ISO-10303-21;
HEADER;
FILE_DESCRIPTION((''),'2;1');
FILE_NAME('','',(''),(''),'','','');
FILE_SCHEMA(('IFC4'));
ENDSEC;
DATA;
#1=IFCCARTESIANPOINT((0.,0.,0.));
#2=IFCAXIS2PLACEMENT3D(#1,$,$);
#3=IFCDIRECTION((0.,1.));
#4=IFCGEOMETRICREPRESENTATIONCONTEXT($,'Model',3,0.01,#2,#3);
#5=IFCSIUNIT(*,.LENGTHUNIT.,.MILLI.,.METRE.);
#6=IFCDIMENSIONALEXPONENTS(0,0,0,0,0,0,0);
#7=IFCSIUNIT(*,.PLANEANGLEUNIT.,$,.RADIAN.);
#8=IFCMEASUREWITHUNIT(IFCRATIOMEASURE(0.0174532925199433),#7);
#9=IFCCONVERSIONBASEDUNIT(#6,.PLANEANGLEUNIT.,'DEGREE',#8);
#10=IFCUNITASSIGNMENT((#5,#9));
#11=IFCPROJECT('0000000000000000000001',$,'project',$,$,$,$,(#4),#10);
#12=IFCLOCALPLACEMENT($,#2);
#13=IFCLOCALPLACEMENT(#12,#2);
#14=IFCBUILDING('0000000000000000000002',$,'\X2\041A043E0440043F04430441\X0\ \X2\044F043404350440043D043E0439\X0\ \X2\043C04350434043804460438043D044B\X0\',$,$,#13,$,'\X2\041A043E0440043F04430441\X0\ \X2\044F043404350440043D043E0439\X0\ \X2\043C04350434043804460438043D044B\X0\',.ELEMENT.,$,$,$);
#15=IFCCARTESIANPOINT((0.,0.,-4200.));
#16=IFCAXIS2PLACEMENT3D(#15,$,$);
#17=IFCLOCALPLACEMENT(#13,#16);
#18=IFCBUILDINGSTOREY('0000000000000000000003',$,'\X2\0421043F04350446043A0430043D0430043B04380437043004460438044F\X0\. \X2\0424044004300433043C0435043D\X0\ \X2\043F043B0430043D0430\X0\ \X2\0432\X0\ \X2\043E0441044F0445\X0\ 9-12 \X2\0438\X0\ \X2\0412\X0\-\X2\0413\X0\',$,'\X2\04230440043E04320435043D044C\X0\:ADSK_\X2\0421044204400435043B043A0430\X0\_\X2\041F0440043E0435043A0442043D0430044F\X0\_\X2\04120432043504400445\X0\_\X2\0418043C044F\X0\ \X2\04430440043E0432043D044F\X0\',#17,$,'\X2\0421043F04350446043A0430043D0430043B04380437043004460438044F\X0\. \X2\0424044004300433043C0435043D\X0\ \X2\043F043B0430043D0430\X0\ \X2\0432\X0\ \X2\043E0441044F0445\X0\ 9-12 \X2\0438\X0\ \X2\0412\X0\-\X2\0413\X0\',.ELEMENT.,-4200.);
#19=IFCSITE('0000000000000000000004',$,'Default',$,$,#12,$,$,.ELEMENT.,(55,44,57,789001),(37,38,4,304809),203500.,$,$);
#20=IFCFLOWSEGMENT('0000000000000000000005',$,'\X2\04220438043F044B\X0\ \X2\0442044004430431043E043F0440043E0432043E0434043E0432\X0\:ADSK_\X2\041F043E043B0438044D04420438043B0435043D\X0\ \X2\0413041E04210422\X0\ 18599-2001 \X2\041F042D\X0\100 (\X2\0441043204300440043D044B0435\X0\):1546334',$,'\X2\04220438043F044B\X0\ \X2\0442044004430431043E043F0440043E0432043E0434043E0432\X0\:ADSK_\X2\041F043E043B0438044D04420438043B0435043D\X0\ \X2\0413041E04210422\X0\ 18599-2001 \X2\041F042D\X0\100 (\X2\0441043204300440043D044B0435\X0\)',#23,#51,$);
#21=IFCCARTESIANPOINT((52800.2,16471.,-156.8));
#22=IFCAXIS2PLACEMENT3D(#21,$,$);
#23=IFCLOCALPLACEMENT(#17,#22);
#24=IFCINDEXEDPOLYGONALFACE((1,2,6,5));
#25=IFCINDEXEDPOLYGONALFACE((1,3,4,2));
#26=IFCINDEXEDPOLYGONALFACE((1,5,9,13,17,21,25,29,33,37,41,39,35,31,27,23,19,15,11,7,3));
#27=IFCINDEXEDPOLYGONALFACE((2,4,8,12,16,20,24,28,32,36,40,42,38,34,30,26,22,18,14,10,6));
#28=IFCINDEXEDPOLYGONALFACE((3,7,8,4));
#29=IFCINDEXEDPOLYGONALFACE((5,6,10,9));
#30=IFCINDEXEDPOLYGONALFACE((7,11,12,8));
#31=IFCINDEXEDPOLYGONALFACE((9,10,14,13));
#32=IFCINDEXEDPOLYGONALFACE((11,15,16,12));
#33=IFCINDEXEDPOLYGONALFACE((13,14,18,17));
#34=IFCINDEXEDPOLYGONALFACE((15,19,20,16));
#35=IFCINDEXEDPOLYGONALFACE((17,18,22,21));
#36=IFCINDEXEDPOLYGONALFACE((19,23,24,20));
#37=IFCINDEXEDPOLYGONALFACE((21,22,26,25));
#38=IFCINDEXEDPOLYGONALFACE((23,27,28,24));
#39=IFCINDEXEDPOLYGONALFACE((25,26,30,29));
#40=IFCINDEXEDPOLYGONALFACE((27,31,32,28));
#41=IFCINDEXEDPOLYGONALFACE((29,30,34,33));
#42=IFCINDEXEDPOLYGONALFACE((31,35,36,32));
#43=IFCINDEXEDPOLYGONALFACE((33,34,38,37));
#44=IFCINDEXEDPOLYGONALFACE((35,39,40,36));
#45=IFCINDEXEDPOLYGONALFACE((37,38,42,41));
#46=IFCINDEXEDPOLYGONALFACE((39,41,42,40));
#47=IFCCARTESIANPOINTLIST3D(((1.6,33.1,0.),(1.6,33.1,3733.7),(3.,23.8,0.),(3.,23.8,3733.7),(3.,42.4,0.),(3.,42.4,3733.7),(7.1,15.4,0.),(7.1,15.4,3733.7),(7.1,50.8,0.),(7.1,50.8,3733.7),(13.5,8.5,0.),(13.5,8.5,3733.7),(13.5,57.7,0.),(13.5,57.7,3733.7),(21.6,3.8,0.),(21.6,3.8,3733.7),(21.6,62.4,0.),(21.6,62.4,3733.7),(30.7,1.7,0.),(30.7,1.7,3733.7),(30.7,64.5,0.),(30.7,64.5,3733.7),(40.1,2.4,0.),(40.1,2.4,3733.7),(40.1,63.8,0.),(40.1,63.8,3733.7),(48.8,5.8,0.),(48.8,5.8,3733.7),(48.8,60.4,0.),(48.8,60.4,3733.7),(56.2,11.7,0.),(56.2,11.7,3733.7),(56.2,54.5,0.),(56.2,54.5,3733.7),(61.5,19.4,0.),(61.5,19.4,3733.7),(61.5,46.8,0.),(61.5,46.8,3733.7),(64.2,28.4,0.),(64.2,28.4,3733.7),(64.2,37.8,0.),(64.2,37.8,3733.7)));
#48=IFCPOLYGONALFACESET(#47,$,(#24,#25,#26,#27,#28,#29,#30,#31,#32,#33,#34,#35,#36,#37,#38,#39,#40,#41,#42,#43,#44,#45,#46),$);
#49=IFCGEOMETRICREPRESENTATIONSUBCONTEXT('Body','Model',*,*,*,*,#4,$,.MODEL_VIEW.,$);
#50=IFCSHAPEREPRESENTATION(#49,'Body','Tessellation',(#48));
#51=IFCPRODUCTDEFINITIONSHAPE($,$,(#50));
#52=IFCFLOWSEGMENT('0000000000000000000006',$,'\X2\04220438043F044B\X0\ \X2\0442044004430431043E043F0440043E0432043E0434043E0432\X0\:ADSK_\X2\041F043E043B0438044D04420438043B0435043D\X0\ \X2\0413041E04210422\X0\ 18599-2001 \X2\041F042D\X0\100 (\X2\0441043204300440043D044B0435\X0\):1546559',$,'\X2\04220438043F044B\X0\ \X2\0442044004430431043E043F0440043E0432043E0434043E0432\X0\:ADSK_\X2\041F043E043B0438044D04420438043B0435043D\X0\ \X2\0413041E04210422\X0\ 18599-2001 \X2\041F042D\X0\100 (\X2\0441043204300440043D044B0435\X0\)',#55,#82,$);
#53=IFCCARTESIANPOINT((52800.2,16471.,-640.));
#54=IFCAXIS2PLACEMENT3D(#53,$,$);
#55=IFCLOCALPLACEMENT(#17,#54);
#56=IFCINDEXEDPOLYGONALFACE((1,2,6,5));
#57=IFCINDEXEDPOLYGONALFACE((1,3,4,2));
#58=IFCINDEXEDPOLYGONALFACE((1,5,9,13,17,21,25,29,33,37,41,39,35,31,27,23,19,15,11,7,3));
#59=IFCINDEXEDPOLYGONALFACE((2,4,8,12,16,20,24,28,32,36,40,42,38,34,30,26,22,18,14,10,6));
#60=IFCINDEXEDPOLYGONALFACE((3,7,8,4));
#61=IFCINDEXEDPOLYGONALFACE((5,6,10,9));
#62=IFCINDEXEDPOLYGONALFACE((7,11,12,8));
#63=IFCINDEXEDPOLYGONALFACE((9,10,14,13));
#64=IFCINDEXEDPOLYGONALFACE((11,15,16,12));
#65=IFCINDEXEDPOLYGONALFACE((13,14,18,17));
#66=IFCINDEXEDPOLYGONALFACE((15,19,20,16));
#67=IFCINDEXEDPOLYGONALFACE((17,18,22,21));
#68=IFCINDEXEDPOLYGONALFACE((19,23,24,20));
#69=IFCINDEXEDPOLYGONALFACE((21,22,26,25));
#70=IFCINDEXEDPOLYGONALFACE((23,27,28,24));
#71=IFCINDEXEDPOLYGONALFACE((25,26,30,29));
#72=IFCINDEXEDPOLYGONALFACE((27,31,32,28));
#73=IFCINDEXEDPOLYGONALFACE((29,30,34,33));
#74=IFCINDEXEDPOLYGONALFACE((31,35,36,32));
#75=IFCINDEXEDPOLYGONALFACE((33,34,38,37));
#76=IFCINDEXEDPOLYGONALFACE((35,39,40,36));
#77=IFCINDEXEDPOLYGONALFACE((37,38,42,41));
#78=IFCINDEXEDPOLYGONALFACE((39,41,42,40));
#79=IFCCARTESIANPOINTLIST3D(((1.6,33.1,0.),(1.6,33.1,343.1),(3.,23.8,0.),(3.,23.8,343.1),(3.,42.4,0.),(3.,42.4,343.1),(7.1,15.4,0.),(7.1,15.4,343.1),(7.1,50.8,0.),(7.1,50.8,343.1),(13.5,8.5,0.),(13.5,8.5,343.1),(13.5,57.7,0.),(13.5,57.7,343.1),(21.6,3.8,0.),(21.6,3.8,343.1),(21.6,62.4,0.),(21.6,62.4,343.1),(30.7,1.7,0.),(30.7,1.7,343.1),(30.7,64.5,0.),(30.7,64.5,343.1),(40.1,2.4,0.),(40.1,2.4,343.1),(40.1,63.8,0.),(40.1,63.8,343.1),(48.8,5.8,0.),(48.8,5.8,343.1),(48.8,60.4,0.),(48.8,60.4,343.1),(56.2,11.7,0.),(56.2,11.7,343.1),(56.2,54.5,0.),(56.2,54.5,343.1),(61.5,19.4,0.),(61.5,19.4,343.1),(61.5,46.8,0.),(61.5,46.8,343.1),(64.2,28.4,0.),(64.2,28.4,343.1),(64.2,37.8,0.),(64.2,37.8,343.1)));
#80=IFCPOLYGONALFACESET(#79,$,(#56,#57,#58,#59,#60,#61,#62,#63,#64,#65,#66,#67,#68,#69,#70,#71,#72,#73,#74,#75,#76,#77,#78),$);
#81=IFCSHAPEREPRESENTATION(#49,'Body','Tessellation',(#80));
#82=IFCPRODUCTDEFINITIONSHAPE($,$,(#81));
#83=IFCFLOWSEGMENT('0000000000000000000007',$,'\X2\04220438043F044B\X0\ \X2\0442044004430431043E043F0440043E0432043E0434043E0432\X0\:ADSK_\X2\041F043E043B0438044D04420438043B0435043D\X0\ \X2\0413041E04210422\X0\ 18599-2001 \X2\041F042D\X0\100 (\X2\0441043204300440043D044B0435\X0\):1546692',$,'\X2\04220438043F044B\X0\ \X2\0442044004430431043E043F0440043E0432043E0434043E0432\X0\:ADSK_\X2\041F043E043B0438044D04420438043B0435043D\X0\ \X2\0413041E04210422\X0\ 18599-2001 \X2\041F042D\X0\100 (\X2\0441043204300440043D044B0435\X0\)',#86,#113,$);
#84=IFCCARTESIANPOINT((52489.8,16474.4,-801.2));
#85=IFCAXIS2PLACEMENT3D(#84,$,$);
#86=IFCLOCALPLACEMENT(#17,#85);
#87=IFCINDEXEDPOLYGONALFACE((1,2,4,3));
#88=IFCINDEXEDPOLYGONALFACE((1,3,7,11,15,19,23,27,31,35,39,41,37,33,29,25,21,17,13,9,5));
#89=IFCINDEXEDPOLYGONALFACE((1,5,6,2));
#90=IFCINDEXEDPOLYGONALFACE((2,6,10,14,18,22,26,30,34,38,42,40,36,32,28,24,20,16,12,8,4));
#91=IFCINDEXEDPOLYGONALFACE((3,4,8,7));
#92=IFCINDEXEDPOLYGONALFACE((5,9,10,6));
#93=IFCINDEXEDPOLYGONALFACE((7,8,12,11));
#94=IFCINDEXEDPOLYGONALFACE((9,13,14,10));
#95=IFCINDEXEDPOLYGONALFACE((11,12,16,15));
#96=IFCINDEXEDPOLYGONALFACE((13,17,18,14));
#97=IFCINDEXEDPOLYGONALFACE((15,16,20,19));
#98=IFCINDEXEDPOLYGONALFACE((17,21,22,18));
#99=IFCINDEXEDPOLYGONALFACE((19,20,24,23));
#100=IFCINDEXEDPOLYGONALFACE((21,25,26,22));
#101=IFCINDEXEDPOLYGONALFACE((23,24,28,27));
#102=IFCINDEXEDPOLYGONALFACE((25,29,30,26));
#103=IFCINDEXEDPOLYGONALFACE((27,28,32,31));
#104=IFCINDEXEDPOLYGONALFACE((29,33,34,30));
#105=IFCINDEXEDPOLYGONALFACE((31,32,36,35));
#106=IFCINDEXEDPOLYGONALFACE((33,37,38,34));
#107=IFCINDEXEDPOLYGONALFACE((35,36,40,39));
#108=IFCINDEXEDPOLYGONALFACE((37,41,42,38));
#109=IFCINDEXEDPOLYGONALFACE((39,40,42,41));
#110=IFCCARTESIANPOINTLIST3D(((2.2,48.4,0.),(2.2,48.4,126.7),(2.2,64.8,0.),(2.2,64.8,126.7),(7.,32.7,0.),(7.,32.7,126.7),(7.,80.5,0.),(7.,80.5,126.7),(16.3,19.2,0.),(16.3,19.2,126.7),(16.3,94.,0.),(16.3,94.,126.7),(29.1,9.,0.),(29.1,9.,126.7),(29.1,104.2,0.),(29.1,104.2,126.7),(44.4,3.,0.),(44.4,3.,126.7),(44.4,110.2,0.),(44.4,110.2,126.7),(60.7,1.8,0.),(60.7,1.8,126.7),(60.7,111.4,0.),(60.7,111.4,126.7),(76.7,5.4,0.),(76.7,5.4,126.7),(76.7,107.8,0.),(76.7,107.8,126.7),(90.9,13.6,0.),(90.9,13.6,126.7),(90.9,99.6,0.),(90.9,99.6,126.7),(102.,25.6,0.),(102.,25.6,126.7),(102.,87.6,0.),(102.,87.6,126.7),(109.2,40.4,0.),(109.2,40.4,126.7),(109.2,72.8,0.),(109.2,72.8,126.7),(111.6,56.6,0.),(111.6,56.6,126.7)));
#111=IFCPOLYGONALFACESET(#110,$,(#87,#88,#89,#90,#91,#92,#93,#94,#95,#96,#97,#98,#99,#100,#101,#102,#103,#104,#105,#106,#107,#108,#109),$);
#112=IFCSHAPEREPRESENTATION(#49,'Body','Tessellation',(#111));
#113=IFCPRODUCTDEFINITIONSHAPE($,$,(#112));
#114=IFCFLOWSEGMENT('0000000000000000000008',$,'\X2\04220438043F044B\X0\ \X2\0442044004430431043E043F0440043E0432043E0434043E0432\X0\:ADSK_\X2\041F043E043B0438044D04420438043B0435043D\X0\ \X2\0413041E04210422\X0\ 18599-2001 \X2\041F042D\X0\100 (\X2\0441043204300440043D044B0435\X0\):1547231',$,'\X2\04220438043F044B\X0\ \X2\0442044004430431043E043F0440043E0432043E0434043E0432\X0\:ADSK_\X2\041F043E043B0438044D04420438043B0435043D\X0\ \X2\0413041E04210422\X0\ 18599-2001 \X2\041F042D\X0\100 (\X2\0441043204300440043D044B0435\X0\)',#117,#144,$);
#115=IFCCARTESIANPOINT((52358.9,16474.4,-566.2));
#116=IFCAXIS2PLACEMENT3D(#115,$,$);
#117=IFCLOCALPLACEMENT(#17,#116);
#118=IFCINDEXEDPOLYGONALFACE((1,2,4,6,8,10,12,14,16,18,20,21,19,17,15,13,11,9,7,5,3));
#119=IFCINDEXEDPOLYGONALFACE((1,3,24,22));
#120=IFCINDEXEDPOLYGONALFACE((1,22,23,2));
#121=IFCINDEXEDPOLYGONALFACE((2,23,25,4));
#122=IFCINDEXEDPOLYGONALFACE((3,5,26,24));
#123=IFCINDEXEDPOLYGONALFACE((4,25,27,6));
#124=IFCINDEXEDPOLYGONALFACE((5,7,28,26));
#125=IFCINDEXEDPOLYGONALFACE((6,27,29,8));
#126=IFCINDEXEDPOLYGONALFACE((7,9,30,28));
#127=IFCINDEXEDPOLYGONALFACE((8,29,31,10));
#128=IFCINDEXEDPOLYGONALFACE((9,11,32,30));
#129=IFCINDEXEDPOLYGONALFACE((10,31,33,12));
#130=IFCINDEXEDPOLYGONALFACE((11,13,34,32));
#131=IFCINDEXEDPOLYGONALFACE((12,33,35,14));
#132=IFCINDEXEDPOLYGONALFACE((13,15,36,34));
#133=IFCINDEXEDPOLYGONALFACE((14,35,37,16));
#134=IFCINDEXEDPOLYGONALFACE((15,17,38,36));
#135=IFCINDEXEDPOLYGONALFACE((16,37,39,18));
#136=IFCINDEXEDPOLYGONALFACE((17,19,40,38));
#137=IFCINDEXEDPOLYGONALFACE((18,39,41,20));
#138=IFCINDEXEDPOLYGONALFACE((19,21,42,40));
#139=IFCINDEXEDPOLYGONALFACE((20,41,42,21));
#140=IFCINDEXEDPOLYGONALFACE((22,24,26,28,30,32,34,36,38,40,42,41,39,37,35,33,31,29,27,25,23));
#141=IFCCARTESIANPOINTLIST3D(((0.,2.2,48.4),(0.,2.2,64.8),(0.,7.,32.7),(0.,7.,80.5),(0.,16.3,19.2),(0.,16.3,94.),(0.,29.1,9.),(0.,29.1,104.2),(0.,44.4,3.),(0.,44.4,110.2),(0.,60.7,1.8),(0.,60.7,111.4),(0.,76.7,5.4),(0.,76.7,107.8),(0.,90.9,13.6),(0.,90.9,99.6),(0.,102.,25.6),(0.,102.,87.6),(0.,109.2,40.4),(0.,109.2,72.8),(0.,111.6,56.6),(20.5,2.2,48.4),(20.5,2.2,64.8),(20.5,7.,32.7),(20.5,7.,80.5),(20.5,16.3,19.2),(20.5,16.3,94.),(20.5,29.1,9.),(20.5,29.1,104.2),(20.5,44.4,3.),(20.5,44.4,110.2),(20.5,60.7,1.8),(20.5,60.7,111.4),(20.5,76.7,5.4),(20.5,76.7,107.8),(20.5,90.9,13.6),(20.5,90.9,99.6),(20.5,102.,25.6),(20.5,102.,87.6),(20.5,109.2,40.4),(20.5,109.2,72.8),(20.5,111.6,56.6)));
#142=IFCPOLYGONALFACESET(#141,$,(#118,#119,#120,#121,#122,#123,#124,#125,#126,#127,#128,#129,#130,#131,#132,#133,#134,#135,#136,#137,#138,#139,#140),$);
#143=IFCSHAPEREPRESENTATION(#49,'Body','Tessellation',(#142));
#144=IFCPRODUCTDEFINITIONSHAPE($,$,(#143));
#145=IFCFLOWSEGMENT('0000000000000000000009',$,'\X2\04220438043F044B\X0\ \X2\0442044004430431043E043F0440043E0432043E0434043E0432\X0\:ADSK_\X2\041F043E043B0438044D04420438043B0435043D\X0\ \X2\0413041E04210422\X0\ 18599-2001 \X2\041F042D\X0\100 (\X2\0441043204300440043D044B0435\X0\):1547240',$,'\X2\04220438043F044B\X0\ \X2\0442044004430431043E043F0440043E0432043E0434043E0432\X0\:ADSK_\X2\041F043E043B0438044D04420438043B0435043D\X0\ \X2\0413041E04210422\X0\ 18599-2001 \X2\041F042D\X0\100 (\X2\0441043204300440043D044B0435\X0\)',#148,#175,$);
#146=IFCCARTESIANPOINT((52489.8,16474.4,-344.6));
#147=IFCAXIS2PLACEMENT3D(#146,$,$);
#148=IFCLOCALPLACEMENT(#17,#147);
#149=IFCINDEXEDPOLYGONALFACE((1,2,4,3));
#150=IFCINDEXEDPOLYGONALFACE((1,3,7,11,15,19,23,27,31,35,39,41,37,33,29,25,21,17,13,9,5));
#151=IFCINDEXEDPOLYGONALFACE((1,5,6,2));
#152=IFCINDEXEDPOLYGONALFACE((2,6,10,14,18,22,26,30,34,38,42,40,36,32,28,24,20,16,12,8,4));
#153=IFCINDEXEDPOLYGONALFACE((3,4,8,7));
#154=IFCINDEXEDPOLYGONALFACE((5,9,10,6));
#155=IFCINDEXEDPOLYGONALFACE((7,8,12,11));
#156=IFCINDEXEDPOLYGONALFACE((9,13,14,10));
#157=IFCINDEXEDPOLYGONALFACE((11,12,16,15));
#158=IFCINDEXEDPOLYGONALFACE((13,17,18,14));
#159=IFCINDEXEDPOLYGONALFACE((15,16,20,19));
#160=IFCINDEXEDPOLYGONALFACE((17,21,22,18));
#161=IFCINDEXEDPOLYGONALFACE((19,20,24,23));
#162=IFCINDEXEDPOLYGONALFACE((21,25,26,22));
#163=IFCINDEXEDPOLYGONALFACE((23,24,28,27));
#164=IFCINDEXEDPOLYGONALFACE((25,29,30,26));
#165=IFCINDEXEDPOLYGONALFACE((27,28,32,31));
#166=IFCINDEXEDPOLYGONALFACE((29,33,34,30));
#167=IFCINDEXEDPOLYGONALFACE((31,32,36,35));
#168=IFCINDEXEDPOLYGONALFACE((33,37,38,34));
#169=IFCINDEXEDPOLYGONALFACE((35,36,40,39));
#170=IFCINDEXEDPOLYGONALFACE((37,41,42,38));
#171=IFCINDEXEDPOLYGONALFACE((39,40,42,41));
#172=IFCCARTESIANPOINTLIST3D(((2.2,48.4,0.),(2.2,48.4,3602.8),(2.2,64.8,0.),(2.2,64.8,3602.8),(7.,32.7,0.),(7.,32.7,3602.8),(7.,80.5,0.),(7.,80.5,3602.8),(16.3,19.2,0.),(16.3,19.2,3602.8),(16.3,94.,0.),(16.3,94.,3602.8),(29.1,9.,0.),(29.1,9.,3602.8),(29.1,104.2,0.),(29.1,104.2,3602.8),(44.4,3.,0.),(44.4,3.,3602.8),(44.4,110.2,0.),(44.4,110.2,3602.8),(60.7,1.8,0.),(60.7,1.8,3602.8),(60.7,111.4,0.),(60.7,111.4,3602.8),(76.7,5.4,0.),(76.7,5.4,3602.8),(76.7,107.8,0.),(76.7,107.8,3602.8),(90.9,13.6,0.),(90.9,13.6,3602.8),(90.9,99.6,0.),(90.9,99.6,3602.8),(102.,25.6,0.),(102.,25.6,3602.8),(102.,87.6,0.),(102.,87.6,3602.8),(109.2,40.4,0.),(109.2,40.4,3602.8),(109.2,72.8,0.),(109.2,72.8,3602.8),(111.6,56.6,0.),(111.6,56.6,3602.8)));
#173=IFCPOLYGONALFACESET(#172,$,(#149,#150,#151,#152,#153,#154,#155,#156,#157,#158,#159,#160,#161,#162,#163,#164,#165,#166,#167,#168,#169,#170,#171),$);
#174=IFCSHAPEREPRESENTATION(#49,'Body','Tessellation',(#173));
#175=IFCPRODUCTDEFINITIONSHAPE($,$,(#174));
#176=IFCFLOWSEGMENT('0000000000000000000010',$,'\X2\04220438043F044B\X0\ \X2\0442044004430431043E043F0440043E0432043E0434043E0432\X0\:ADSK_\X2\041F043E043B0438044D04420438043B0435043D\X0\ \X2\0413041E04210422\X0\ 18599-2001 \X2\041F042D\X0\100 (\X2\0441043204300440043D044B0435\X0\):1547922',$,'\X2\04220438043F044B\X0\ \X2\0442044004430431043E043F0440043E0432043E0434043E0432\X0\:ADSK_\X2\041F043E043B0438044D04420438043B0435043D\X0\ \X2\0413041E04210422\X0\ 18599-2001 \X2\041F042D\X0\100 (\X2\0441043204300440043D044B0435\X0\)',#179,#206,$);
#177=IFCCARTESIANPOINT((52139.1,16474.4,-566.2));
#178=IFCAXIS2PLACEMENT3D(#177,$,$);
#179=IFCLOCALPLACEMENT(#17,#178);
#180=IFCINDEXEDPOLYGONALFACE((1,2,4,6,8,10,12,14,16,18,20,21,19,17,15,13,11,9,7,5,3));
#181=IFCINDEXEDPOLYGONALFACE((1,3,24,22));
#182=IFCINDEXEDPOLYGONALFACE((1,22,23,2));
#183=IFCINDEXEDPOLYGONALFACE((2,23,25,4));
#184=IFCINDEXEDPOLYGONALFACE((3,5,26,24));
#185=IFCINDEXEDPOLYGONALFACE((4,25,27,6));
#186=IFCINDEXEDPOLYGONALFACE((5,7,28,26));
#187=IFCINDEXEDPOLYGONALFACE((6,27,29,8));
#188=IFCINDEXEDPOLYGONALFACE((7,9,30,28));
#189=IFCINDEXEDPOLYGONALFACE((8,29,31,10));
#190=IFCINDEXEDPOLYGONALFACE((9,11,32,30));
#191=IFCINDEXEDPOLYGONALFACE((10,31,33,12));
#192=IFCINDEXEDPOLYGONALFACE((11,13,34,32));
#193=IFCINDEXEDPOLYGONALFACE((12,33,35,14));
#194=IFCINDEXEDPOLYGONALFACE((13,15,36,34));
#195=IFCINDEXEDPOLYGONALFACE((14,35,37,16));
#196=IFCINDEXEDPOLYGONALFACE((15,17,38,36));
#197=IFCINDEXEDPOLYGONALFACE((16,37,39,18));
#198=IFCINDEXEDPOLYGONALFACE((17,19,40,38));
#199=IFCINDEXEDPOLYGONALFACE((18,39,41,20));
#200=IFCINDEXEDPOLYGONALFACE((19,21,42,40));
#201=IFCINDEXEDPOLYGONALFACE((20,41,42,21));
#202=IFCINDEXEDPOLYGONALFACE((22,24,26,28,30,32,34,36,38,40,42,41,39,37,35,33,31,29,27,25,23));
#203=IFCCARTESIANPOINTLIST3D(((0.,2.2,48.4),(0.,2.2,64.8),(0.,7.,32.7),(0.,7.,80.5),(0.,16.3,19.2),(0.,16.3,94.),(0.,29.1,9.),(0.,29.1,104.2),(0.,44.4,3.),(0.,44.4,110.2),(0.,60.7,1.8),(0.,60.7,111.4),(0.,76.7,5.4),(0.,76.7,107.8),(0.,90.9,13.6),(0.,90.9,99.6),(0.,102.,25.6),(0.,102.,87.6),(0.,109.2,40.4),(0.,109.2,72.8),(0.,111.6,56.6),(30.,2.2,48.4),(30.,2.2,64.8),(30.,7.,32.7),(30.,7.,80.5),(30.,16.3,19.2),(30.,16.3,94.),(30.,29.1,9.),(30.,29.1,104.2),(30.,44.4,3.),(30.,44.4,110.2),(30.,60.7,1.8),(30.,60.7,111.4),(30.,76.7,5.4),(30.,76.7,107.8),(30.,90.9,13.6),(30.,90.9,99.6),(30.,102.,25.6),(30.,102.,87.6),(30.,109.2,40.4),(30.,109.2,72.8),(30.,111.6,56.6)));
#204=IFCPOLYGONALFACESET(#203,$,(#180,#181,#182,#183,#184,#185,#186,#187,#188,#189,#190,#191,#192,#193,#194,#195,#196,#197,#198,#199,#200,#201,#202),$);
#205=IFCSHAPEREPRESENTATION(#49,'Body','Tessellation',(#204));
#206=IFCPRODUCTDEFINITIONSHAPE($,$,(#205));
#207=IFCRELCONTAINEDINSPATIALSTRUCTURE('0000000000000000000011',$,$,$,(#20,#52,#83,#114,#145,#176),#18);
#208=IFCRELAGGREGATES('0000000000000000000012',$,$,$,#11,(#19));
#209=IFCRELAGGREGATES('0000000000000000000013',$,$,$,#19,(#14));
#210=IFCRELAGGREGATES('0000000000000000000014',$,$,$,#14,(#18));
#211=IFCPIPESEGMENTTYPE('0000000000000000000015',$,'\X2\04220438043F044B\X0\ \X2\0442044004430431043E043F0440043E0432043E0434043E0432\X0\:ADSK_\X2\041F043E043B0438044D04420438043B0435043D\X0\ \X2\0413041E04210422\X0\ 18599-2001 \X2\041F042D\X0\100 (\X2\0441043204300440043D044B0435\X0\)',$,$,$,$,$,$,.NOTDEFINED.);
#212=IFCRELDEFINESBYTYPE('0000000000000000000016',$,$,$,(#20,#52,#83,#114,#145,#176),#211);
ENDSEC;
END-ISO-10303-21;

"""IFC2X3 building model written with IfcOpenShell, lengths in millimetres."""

from ifc_helpers import new_model, entity, si_unit, converted_unit, direction, frame, origin, origin_2d_with_axis, place, context, subcontext, project, spatial, circle, extrude, type_object, element, save


model = new_model("IFC2X3")

# Units and contexts
model_context = context("Model", 3, precision=0.01, world=origin(), true_north=direction((0.0, 1.0)))
body_context = subcontext(model_context, "Body", "Model", "MODEL_VIEW")
ifc_project = project(units=[si_unit("LENGTHUNIT", "METRE", prefix="MILLI"), converted_unit("PLANEANGLEUNIT", "DEGREE", entity("IfcRatioMeasure", 0.0174532925199433), si_unit("PLANEANGLEUNIT", "RADIAN"), dimensions=[0, 0, 0, 0, 0, 0, 0])], contexts=[model_context])

# Site, building, storey
site_placement = place(None, origin())
site = spatial("IfcSite", under=ifc_project, at=site_placement, Name="Default", CompositionType="ELEMENT", RefLatitude=(55, 44, 57, 789001), RefLongitude=(37, 38, 4, 304809), RefElevation=203500.0)
building_placement = place(site_placement, origin())
building = spatial("IfcBuilding", under=site, at=building_placement, Name="Корпус ядерной медицины", LongName="Корпус ядерной медицины", CompositionType="ELEMENT")
storey_placement = place(building_placement, frame((0.0, 0.0, -4200.0)))
storey = spatial("IfcBuildingStorey", under=building, at=storey_placement, Name="Спецканализация. Фрагмен плана в осях 9-12 и В-Г", ObjectType="Уровень:ADSK_Стрелка_Проектная_Вверх_Имя уровня", LongName="Спецканализация. Фрагмен плана в осях 9-12 и В-Г", CompositionType="ELEMENT", Elevation=-4200.0)

# Flow segments
pipe_segment_type = type_object("IfcPipeSegmentType", Name="Типы трубопроводов:ADSK_Полиэтилен ГОСТ 18599-2001 ПЭ100 (сварные)", PredefinedType="NOTDEFINED")
flow_segment_1_placement = place(storey_placement, frame((52800.2, 16471.0, -156.8)))
element("IfcFlowSegment", 1, at=flow_segment_1_placement, inside=storey, type_object=pipe_segment_type, Name="Типы трубопроводов:ADSK_Полиэтилен ГОСТ 18599-2001 ПЭ100 (сварные):1546334", ObjectType="Типы трубопроводов:ADSK_Полиэтилен ГОСТ 18599-2001 ПЭ100 (сварные)", context=body_context, shape_type="SweptSolid", body=[
    extrude(circle(Radius=31.5, at=origin_2d_with_axis()), frame((33.1, 33.1, 0.0), z_axis=(0.0, 0.0, 1.0), x_axis=(-1.0, 0.0, 0.0)), (0.0, 0.0, 1.0), 3733.7),
])
flow_segment_2_placement = place(storey_placement, frame((52800.2, 16471.0, -640.0)))
element("IfcFlowSegment", 2, at=flow_segment_2_placement, inside=storey, type_object=pipe_segment_type, Name="Типы трубопроводов:ADSK_Полиэтилен ГОСТ 18599-2001 ПЭ100 (сварные):1546559", ObjectType="Типы трубопроводов:ADSK_Полиэтилен ГОСТ 18599-2001 ПЭ100 (сварные)", context=body_context, shape_type="SweptSolid", body=[
    extrude(circle(Radius=31.5, at=origin_2d_with_axis()), frame((33.1, 33.1, 0.0), z_axis=(0.0, 0.0, 1.0), x_axis=(-1.0, 0.0, 0.0)), (0.0, 0.0, 1.0), 343.1),
])
flow_segment_3_placement = place(storey_placement, frame((52489.8, 16474.4, -801.2)))
element("IfcFlowSegment", 3, at=flow_segment_3_placement, inside=storey, type_object=pipe_segment_type, Name="Типы трубопроводов:ADSK_Полиэтилен ГОСТ 18599-2001 ПЭ100 (сварные):1546692", ObjectType="Типы трубопроводов:ADSK_Полиэтилен ГОСТ 18599-2001 ПЭ100 (сварные)", context=body_context, shape_type="SweptSolid", body=[
    extrude(circle(Radius=55.0, at=origin_2d_with_axis()), frame((56.6, 56.6, 0.0)), (0.0, 0.0, 1.0), 126.7),
])
flow_segment_4_placement = place(storey_placement, frame((52358.9, 16474.4, -566.2)))
element("IfcFlowSegment", 4, at=flow_segment_4_placement, inside=storey, type_object=pipe_segment_type, Name="Типы трубопроводов:ADSK_Полиэтилен ГОСТ 18599-2001 ПЭ100 (сварные):1547231", ObjectType="Типы трубопроводов:ADSK_Полиэтилен ГОСТ 18599-2001 ПЭ100 (сварные)", context=body_context, shape_type="SweptSolid", body=[
    extrude(circle(Radius=55.0, at=origin_2d_with_axis()), frame((0.0, 56.6, 56.6), z_axis=(1.0, 0.0, 0.0), x_axis=(0.0, 1.0, 0.0)), (0.0, 0.0, 1.0), 20.5),
])
flow_segment_5_placement = place(storey_placement, frame((52489.8, 16474.4, -344.6)))
element("IfcFlowSegment", 5, at=flow_segment_5_placement, inside=storey, type_object=pipe_segment_type, Name="Типы трубопроводов:ADSK_Полиэтилен ГОСТ 18599-2001 ПЭ100 (сварные):1547240", ObjectType="Типы трубопроводов:ADSK_Полиэтилен ГОСТ 18599-2001 ПЭ100 (сварные)", context=body_context, shape_type="SweptSolid", body=[
    extrude(circle(Radius=55.0, at=origin_2d_with_axis()), frame((56.6, 56.6, 0.0)), (0.0, 0.0, 1.0), 3602.8),
])
flow_segment_6_placement = place(storey_placement, frame((52139.1, 16474.4, -566.2)))
element("IfcFlowSegment", 6, at=flow_segment_6_placement, inside=storey, type_object=pipe_segment_type, Name="Типы трубопроводов:ADSK_Полиэтилен ГОСТ 18599-2001 ПЭ100 (сварные):1547922", ObjectType="Типы трубопроводов:ADSK_Полиэтилен ГОСТ 18599-2001 ПЭ100 (сварные)", context=body_context, shape_type="SweptSolid", body=[
    extrude(circle(Radius=55.0, at=origin_2d_with_axis()), frame((0.0, 56.6, 56.6), z_axis=(1.0, 0.0, 0.0), x_axis=(0.0, 1.0, 0.0)), (0.0, 0.0, 1.0), 30.0),
])

save(model, "model.ifc")
